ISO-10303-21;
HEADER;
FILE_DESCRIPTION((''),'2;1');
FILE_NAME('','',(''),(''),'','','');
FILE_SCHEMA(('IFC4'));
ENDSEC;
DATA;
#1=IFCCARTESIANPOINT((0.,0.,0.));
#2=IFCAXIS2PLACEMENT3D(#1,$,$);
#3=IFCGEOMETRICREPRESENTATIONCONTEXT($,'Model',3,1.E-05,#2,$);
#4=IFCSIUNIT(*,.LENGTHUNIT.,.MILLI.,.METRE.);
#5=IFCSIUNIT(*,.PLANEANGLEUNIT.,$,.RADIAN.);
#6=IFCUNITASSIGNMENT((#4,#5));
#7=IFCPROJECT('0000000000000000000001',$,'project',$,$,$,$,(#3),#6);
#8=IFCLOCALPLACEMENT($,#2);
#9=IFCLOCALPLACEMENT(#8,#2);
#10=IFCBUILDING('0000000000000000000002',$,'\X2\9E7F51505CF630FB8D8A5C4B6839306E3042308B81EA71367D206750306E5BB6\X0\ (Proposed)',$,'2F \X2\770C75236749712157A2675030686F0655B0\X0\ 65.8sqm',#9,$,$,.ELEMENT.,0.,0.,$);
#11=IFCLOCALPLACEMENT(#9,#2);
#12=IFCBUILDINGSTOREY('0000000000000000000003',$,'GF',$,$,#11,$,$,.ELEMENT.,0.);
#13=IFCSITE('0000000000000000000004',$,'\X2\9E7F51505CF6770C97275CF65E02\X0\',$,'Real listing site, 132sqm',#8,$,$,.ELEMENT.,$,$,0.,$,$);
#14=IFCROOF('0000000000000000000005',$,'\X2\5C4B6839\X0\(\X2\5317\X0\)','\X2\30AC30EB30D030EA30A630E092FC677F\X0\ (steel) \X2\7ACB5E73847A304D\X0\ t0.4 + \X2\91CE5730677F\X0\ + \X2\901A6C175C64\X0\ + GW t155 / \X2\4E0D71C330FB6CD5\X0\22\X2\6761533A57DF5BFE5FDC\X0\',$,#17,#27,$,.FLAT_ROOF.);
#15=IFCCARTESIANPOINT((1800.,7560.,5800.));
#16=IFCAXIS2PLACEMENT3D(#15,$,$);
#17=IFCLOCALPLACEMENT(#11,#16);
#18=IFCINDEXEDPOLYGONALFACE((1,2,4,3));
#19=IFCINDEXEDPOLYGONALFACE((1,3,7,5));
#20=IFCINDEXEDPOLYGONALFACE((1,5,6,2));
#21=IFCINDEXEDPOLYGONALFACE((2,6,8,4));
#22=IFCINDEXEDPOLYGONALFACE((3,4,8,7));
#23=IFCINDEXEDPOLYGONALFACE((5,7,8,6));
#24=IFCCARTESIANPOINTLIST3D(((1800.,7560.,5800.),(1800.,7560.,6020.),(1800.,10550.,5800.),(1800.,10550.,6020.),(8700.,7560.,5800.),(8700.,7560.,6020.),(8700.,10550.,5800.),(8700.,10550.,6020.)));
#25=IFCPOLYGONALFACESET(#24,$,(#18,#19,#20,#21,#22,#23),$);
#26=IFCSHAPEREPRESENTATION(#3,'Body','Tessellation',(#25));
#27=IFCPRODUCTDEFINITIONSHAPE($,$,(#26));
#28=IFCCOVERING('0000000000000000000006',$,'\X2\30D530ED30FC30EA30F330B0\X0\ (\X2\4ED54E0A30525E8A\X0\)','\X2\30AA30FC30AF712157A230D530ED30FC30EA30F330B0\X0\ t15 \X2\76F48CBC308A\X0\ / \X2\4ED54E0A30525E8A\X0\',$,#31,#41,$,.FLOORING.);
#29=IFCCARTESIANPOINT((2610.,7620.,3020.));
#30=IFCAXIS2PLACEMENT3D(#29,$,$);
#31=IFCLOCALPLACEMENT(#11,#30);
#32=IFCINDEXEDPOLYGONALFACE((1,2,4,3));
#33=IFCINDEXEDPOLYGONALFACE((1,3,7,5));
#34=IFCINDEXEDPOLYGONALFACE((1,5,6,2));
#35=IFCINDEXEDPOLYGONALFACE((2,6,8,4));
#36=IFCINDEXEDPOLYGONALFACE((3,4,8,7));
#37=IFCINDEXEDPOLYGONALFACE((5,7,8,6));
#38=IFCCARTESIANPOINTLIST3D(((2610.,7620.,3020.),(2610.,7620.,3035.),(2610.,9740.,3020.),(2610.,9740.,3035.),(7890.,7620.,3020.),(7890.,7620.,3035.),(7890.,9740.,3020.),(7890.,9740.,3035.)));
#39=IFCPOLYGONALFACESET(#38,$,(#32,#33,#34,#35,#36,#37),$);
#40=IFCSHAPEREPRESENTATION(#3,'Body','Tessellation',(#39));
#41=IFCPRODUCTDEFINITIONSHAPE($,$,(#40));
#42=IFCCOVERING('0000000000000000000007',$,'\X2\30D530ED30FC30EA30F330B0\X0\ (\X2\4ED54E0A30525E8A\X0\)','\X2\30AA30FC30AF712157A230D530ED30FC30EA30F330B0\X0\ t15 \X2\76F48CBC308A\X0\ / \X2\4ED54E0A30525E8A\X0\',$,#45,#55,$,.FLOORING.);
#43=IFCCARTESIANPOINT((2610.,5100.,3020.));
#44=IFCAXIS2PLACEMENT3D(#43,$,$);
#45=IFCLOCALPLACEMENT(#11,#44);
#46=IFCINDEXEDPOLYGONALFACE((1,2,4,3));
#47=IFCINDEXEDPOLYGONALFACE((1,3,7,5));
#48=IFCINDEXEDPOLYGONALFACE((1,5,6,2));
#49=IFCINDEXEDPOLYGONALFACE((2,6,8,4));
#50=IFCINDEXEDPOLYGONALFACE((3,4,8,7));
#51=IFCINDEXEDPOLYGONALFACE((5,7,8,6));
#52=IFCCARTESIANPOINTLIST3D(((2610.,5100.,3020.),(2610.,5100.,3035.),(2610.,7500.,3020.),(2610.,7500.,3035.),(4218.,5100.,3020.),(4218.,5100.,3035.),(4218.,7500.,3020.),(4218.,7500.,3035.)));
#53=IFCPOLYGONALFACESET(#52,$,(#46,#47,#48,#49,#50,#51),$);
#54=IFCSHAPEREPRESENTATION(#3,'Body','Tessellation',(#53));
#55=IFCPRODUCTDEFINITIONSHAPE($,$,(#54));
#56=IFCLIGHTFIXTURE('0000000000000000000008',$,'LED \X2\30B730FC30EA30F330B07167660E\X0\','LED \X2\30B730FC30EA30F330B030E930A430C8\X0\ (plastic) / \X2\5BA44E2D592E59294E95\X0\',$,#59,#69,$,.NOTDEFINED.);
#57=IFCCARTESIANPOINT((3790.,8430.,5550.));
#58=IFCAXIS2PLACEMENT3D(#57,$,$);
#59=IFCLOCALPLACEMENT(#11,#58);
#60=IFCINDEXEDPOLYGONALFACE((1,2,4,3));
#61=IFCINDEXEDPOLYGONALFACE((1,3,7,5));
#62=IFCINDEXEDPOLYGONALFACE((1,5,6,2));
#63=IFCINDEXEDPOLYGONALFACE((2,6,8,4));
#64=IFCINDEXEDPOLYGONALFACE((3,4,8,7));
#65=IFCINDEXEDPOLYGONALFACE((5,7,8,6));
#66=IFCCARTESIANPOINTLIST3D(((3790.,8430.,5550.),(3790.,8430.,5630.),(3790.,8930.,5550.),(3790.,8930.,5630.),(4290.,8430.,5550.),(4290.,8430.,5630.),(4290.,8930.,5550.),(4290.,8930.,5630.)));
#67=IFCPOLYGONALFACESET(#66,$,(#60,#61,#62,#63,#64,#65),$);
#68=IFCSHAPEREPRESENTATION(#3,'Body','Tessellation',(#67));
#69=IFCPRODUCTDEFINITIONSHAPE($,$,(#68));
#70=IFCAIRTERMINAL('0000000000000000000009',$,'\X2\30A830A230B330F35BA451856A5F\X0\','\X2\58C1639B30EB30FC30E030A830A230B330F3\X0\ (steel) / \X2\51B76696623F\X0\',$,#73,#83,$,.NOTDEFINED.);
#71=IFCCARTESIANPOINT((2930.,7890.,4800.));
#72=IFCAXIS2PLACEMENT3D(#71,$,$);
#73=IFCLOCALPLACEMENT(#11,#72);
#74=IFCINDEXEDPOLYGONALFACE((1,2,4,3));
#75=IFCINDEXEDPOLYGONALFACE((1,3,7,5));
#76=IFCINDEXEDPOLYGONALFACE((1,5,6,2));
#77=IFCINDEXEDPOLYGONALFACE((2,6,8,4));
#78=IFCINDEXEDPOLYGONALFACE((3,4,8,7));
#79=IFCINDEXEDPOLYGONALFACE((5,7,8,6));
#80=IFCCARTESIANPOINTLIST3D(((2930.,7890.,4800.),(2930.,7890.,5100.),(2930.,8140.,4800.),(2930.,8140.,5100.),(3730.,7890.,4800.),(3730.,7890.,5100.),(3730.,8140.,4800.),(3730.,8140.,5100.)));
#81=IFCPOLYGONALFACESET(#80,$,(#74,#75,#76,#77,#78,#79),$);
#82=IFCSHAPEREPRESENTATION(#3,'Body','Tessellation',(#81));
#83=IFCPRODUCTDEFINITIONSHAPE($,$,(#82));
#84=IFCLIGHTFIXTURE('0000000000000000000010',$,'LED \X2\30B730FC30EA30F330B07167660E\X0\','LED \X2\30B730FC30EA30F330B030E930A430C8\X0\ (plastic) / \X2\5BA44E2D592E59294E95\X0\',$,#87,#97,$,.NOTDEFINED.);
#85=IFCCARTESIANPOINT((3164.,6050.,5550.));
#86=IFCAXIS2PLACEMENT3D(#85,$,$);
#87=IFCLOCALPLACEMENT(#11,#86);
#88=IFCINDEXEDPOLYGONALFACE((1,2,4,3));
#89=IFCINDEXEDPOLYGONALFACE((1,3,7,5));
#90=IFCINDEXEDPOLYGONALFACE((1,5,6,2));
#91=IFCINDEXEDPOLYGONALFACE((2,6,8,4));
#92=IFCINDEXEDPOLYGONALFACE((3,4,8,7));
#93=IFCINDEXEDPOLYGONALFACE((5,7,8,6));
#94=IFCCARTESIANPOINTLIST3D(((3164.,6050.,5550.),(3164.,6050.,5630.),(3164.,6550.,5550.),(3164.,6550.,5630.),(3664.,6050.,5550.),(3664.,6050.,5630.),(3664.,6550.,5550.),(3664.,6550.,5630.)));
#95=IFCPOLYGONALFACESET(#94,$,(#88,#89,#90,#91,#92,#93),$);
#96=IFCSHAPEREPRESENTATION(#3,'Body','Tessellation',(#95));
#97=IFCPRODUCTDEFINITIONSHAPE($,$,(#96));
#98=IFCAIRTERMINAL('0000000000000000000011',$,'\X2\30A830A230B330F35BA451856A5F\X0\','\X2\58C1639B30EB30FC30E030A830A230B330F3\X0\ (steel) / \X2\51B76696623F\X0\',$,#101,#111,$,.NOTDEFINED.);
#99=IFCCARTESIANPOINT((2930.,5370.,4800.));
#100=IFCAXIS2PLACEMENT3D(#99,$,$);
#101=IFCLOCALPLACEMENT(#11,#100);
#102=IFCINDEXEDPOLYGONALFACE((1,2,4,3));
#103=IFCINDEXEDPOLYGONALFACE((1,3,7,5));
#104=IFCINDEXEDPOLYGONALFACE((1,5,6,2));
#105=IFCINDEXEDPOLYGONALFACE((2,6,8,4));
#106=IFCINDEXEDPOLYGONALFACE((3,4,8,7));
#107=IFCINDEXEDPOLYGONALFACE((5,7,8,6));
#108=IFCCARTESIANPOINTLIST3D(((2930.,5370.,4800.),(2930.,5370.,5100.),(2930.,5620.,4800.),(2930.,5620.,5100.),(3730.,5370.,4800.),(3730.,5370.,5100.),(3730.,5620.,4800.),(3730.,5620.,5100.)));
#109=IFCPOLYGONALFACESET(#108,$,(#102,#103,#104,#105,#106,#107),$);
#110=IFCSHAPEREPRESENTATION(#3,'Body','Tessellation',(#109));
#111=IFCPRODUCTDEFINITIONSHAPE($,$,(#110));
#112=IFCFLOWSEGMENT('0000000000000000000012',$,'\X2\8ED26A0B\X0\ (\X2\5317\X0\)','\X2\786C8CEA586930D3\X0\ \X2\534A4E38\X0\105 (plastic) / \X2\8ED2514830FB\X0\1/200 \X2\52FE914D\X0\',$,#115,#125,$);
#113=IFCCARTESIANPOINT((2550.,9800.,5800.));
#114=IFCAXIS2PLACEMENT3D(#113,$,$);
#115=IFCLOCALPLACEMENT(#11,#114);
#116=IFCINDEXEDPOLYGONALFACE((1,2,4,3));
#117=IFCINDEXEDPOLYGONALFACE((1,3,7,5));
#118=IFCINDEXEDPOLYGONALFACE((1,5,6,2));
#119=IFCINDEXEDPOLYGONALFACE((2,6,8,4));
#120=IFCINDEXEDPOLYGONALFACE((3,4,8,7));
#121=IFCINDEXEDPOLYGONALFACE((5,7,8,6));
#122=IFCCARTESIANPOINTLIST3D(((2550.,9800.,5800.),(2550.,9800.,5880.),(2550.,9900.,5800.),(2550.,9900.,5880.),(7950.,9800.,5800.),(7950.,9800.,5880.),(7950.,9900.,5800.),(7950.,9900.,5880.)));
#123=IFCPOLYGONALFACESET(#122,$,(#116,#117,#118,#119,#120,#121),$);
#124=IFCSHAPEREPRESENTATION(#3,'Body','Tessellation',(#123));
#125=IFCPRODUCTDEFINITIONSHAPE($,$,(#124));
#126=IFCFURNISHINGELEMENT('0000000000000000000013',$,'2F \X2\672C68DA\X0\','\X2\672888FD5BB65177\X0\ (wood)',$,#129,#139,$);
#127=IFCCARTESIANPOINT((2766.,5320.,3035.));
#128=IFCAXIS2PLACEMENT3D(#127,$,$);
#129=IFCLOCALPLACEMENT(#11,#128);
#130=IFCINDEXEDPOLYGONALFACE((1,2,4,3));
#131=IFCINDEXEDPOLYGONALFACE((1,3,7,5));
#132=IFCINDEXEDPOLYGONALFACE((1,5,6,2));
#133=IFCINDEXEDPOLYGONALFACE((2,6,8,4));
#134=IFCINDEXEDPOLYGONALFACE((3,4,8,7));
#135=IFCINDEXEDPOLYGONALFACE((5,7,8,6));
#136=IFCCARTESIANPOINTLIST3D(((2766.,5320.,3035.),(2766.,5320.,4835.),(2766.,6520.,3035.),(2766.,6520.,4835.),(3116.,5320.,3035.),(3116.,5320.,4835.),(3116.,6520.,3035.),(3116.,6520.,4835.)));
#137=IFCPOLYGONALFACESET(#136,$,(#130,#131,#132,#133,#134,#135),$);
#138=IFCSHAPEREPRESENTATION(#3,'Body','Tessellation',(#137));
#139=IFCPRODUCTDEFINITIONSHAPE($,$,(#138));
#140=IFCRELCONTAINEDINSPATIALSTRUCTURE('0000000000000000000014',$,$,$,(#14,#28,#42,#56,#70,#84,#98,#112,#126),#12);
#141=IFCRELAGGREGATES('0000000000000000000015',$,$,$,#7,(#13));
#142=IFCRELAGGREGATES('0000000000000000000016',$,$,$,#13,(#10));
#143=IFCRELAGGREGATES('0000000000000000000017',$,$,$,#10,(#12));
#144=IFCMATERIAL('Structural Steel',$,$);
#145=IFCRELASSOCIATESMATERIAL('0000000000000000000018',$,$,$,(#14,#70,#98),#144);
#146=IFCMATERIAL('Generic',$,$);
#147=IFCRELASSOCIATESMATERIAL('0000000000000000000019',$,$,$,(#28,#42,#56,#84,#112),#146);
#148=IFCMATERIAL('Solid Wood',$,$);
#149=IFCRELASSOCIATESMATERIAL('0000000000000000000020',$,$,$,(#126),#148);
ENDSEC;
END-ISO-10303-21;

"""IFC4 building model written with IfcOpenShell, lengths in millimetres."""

from ifc_helpers import new_model, si_unit, frame, frame_2d, origin, place, context, project, spatial, rectangle, extrude, material, element, save


model = new_model("IFC4")

# Units and contexts
model_context = context("Model", 3, precision=1e-05, world=origin())
ifc_project = project(units=[si_unit("LENGTHUNIT", "METRE", prefix="MILLI"), si_unit("PLANEANGLEUNIT", "RADIAN")], contexts=[model_context])

# Site, building, storey
site_placement = place(None, origin())
site = spatial("IfcSite", under=ifc_project, at=site_placement, Name="鹿児島県霧島市", ObjectType="Real listing site, 132sqm", CompositionType="ELEMENT", RefElevation=0.0)
building_placement = place(site_placement, origin())
building = spatial("IfcBuilding", under=site, at=building_placement, Name="鹿児島・越屋根のある自然素材の家 (Proposed)", ObjectType="2F 県産杉無垢材と漆喰 65.8sqm", CompositionType="ELEMENT", ElevationOfRefHeight=0.0, ElevationOfTerrain=0.0)
storey_placement = place(building_placement, origin())
storey = spatial("IfcBuildingStorey", under=building, at=storey_placement, Name="GF", CompositionType="ELEMENT", Elevation=0.0)

# Shared definitions
ifc_material_1 = material(Name="Solid Wood")

# Roof
ifc_material_2 = material(Name="Structural Steel")
for number, where, name in (
    (1, (1800.0, 7560.0, 5800.0), "屋根(北)"),
):
    element("IfcRoof", number, at=place(storey_placement, frame(where)), inside=storey, material=ifc_material_2, Name=name, Description="ガルバリウム鋼板 (steel) 立平葺き t0.4 + 野地板 + 通気層 + GW t155 / 不燃・法22条区域対応", PredefinedType="FLAT_ROOF", context=model_context, shape_type="SweptSolid", body=[
        extrude(rectangle(XDim=6900.0, YDim=2990.0, at=frame_2d((3450.0, 1495.0))), frame((1800.0, 7560.0, 5800.0)), (0.0, 0.0, 1.0), 220.0),
    ])

# Coverings
ifc_material_3 = material(Name="Generic")
covering_1_placement = place(storey_placement, frame((2610.0, 7620.0, 3020.0)))
element("IfcCovering", 2, at=covering_1_placement, inside=storey, material=ifc_material_3, Name="フローリング (仕上げ床)", Description="オーク無垢フローリング t15 直貼り / 仕上げ床", PredefinedType="FLOORING", context=model_context, shape_type="SweptSolid", body=[
    extrude(rectangle(XDim=5280.0, YDim=2120.0, at=frame_2d((2640.0, 1060.0))), frame((2610.0, 7620.0, 3020.0)), (0.0, 0.0, 1.0), 15.0),
])
covering_2_placement = place(storey_placement, frame((2610.0, 5100.0, 3020.0)))
element("IfcCovering", 3, at=covering_2_placement, inside=storey, material=ifc_material_3, Name="フローリング (仕上げ床)", Description="オーク無垢フローリング t15 直貼り / 仕上げ床", PredefinedType="FLOORING", context=model_context, shape_type="SweptSolid", body=[
    extrude(rectangle(XDim=1608.0, YDim=2400.0, at=frame_2d((804.0, 1200.0))), frame((2610.0, 5100.0, 3020.0)), (0.0, 0.0, 1.0), 15.0),
])

# Light fixture
light_fixture_1_placement = place(storey_placement, frame((3790.0, 8430.0, 5550.0)))
element("IfcLightFixture", 4, at=light_fixture_1_placement, inside=storey, material=ifc_material_3, Name="LED シーリング照明", Description="LED シーリングライト (plastic) / 室中央天井", PredefinedType="NOTDEFINED", context=model_context, shape_type="SweptSolid", body=[
    extrude(rectangle(XDim=500.0, YDim=500.0, at=frame_2d((250.0, 250.0))), frame((3790.0, 8430.0, 5550.0)), (0.0, 0.0, 1.0), 80.0),
])

# Air terminal
air_terminal_1_placement = place(storey_placement, frame((2930.0, 7890.0, 4800.0)))
element("IfcAirTerminal", 5, at=air_terminal_1_placement, inside=storey, material=ifc_material_2, Name="エアコン室内機", Description="壁掛ルームエアコン (steel) / 冷暖房", PredefinedType="NOTDEFINED", context=model_context, shape_type="SweptSolid", body=[
    extrude(rectangle(XDim=800.0, YDim=250.0, at=frame_2d((400.0, 125.0))), frame((2930.0, 7890.0, 4800.0)), (0.0, 0.0, 1.0), 300.0),
])

# Light fixture
light_fixture_2_placement = place(storey_placement, frame((3164.0, 6050.0, 5550.0)))
element("IfcLightFixture", 6, at=light_fixture_2_placement, inside=storey, material=ifc_material_3, Name="LED シーリング照明", Description="LED シーリングライト (plastic) / 室中央天井", PredefinedType="NOTDEFINED", context=model_context, shape_type="SweptSolid", body=[
    extrude(rectangle(XDim=500.0, YDim=500.0, at=frame_2d((250.0, 250.0))), frame((3164.0, 6050.0, 5550.0)), (0.0, 0.0, 1.0), 80.0),
])

# Air terminal
air_terminal_2_placement = place(storey_placement, frame((2930.0, 5370.0, 4800.0)))
element("IfcAirTerminal", 7, at=air_terminal_2_placement, inside=storey, material=ifc_material_2, Name="エアコン室内機", Description="壁掛ルームエアコン (steel) / 冷暖房", PredefinedType="NOTDEFINED", context=model_context, shape_type="SweptSolid", body=[
    extrude(rectangle(XDim=800.0, YDim=250.0, at=frame_2d((400.0, 125.0))), frame((2930.0, 5370.0, 4800.0)), (0.0, 0.0, 1.0), 300.0),
])

# Flow segment
flow_segment_placement = place(storey_placement, frame((2550.0, 9800.0, 5800.0)))
element("IfcFlowSegment", 8, at=flow_segment_placement, inside=storey, material=ifc_material_3, Name="軒樋 (北)", Description="硬質塩ビ 半丸105 (plastic) / 軒先・1/200 勾配", context=model_context, shape_type="SweptSolid", body=[
    extrude(rectangle(XDim=5400.0, YDim=100.0, at=frame_2d((2700.0, 50.0))), frame((2550.0, 9800.0, 5800.0)), (0.0, 0.0, 1.0), 80.0),
])

# Furnishing element
furnishing_placement = place(storey_placement, frame((2766.0, 5320.0, 3035.0)))
element("IfcFurnishingElement", 9, at=furnishing_placement, inside=storey, material=ifc_material_1, Name="2F 本棚", Description="木製家具 (wood)", context=model_context, shape_type="SweptSolid", body=[
    extrude(rectangle(XDim=350.0, YDim=1200.0, at=frame_2d((175.0, 600.0))), frame((2766.0, 5320.0, 3035.0)), (0.0, 0.0, 1.0), 1800.0),
])

save(model, "model.ifc")
